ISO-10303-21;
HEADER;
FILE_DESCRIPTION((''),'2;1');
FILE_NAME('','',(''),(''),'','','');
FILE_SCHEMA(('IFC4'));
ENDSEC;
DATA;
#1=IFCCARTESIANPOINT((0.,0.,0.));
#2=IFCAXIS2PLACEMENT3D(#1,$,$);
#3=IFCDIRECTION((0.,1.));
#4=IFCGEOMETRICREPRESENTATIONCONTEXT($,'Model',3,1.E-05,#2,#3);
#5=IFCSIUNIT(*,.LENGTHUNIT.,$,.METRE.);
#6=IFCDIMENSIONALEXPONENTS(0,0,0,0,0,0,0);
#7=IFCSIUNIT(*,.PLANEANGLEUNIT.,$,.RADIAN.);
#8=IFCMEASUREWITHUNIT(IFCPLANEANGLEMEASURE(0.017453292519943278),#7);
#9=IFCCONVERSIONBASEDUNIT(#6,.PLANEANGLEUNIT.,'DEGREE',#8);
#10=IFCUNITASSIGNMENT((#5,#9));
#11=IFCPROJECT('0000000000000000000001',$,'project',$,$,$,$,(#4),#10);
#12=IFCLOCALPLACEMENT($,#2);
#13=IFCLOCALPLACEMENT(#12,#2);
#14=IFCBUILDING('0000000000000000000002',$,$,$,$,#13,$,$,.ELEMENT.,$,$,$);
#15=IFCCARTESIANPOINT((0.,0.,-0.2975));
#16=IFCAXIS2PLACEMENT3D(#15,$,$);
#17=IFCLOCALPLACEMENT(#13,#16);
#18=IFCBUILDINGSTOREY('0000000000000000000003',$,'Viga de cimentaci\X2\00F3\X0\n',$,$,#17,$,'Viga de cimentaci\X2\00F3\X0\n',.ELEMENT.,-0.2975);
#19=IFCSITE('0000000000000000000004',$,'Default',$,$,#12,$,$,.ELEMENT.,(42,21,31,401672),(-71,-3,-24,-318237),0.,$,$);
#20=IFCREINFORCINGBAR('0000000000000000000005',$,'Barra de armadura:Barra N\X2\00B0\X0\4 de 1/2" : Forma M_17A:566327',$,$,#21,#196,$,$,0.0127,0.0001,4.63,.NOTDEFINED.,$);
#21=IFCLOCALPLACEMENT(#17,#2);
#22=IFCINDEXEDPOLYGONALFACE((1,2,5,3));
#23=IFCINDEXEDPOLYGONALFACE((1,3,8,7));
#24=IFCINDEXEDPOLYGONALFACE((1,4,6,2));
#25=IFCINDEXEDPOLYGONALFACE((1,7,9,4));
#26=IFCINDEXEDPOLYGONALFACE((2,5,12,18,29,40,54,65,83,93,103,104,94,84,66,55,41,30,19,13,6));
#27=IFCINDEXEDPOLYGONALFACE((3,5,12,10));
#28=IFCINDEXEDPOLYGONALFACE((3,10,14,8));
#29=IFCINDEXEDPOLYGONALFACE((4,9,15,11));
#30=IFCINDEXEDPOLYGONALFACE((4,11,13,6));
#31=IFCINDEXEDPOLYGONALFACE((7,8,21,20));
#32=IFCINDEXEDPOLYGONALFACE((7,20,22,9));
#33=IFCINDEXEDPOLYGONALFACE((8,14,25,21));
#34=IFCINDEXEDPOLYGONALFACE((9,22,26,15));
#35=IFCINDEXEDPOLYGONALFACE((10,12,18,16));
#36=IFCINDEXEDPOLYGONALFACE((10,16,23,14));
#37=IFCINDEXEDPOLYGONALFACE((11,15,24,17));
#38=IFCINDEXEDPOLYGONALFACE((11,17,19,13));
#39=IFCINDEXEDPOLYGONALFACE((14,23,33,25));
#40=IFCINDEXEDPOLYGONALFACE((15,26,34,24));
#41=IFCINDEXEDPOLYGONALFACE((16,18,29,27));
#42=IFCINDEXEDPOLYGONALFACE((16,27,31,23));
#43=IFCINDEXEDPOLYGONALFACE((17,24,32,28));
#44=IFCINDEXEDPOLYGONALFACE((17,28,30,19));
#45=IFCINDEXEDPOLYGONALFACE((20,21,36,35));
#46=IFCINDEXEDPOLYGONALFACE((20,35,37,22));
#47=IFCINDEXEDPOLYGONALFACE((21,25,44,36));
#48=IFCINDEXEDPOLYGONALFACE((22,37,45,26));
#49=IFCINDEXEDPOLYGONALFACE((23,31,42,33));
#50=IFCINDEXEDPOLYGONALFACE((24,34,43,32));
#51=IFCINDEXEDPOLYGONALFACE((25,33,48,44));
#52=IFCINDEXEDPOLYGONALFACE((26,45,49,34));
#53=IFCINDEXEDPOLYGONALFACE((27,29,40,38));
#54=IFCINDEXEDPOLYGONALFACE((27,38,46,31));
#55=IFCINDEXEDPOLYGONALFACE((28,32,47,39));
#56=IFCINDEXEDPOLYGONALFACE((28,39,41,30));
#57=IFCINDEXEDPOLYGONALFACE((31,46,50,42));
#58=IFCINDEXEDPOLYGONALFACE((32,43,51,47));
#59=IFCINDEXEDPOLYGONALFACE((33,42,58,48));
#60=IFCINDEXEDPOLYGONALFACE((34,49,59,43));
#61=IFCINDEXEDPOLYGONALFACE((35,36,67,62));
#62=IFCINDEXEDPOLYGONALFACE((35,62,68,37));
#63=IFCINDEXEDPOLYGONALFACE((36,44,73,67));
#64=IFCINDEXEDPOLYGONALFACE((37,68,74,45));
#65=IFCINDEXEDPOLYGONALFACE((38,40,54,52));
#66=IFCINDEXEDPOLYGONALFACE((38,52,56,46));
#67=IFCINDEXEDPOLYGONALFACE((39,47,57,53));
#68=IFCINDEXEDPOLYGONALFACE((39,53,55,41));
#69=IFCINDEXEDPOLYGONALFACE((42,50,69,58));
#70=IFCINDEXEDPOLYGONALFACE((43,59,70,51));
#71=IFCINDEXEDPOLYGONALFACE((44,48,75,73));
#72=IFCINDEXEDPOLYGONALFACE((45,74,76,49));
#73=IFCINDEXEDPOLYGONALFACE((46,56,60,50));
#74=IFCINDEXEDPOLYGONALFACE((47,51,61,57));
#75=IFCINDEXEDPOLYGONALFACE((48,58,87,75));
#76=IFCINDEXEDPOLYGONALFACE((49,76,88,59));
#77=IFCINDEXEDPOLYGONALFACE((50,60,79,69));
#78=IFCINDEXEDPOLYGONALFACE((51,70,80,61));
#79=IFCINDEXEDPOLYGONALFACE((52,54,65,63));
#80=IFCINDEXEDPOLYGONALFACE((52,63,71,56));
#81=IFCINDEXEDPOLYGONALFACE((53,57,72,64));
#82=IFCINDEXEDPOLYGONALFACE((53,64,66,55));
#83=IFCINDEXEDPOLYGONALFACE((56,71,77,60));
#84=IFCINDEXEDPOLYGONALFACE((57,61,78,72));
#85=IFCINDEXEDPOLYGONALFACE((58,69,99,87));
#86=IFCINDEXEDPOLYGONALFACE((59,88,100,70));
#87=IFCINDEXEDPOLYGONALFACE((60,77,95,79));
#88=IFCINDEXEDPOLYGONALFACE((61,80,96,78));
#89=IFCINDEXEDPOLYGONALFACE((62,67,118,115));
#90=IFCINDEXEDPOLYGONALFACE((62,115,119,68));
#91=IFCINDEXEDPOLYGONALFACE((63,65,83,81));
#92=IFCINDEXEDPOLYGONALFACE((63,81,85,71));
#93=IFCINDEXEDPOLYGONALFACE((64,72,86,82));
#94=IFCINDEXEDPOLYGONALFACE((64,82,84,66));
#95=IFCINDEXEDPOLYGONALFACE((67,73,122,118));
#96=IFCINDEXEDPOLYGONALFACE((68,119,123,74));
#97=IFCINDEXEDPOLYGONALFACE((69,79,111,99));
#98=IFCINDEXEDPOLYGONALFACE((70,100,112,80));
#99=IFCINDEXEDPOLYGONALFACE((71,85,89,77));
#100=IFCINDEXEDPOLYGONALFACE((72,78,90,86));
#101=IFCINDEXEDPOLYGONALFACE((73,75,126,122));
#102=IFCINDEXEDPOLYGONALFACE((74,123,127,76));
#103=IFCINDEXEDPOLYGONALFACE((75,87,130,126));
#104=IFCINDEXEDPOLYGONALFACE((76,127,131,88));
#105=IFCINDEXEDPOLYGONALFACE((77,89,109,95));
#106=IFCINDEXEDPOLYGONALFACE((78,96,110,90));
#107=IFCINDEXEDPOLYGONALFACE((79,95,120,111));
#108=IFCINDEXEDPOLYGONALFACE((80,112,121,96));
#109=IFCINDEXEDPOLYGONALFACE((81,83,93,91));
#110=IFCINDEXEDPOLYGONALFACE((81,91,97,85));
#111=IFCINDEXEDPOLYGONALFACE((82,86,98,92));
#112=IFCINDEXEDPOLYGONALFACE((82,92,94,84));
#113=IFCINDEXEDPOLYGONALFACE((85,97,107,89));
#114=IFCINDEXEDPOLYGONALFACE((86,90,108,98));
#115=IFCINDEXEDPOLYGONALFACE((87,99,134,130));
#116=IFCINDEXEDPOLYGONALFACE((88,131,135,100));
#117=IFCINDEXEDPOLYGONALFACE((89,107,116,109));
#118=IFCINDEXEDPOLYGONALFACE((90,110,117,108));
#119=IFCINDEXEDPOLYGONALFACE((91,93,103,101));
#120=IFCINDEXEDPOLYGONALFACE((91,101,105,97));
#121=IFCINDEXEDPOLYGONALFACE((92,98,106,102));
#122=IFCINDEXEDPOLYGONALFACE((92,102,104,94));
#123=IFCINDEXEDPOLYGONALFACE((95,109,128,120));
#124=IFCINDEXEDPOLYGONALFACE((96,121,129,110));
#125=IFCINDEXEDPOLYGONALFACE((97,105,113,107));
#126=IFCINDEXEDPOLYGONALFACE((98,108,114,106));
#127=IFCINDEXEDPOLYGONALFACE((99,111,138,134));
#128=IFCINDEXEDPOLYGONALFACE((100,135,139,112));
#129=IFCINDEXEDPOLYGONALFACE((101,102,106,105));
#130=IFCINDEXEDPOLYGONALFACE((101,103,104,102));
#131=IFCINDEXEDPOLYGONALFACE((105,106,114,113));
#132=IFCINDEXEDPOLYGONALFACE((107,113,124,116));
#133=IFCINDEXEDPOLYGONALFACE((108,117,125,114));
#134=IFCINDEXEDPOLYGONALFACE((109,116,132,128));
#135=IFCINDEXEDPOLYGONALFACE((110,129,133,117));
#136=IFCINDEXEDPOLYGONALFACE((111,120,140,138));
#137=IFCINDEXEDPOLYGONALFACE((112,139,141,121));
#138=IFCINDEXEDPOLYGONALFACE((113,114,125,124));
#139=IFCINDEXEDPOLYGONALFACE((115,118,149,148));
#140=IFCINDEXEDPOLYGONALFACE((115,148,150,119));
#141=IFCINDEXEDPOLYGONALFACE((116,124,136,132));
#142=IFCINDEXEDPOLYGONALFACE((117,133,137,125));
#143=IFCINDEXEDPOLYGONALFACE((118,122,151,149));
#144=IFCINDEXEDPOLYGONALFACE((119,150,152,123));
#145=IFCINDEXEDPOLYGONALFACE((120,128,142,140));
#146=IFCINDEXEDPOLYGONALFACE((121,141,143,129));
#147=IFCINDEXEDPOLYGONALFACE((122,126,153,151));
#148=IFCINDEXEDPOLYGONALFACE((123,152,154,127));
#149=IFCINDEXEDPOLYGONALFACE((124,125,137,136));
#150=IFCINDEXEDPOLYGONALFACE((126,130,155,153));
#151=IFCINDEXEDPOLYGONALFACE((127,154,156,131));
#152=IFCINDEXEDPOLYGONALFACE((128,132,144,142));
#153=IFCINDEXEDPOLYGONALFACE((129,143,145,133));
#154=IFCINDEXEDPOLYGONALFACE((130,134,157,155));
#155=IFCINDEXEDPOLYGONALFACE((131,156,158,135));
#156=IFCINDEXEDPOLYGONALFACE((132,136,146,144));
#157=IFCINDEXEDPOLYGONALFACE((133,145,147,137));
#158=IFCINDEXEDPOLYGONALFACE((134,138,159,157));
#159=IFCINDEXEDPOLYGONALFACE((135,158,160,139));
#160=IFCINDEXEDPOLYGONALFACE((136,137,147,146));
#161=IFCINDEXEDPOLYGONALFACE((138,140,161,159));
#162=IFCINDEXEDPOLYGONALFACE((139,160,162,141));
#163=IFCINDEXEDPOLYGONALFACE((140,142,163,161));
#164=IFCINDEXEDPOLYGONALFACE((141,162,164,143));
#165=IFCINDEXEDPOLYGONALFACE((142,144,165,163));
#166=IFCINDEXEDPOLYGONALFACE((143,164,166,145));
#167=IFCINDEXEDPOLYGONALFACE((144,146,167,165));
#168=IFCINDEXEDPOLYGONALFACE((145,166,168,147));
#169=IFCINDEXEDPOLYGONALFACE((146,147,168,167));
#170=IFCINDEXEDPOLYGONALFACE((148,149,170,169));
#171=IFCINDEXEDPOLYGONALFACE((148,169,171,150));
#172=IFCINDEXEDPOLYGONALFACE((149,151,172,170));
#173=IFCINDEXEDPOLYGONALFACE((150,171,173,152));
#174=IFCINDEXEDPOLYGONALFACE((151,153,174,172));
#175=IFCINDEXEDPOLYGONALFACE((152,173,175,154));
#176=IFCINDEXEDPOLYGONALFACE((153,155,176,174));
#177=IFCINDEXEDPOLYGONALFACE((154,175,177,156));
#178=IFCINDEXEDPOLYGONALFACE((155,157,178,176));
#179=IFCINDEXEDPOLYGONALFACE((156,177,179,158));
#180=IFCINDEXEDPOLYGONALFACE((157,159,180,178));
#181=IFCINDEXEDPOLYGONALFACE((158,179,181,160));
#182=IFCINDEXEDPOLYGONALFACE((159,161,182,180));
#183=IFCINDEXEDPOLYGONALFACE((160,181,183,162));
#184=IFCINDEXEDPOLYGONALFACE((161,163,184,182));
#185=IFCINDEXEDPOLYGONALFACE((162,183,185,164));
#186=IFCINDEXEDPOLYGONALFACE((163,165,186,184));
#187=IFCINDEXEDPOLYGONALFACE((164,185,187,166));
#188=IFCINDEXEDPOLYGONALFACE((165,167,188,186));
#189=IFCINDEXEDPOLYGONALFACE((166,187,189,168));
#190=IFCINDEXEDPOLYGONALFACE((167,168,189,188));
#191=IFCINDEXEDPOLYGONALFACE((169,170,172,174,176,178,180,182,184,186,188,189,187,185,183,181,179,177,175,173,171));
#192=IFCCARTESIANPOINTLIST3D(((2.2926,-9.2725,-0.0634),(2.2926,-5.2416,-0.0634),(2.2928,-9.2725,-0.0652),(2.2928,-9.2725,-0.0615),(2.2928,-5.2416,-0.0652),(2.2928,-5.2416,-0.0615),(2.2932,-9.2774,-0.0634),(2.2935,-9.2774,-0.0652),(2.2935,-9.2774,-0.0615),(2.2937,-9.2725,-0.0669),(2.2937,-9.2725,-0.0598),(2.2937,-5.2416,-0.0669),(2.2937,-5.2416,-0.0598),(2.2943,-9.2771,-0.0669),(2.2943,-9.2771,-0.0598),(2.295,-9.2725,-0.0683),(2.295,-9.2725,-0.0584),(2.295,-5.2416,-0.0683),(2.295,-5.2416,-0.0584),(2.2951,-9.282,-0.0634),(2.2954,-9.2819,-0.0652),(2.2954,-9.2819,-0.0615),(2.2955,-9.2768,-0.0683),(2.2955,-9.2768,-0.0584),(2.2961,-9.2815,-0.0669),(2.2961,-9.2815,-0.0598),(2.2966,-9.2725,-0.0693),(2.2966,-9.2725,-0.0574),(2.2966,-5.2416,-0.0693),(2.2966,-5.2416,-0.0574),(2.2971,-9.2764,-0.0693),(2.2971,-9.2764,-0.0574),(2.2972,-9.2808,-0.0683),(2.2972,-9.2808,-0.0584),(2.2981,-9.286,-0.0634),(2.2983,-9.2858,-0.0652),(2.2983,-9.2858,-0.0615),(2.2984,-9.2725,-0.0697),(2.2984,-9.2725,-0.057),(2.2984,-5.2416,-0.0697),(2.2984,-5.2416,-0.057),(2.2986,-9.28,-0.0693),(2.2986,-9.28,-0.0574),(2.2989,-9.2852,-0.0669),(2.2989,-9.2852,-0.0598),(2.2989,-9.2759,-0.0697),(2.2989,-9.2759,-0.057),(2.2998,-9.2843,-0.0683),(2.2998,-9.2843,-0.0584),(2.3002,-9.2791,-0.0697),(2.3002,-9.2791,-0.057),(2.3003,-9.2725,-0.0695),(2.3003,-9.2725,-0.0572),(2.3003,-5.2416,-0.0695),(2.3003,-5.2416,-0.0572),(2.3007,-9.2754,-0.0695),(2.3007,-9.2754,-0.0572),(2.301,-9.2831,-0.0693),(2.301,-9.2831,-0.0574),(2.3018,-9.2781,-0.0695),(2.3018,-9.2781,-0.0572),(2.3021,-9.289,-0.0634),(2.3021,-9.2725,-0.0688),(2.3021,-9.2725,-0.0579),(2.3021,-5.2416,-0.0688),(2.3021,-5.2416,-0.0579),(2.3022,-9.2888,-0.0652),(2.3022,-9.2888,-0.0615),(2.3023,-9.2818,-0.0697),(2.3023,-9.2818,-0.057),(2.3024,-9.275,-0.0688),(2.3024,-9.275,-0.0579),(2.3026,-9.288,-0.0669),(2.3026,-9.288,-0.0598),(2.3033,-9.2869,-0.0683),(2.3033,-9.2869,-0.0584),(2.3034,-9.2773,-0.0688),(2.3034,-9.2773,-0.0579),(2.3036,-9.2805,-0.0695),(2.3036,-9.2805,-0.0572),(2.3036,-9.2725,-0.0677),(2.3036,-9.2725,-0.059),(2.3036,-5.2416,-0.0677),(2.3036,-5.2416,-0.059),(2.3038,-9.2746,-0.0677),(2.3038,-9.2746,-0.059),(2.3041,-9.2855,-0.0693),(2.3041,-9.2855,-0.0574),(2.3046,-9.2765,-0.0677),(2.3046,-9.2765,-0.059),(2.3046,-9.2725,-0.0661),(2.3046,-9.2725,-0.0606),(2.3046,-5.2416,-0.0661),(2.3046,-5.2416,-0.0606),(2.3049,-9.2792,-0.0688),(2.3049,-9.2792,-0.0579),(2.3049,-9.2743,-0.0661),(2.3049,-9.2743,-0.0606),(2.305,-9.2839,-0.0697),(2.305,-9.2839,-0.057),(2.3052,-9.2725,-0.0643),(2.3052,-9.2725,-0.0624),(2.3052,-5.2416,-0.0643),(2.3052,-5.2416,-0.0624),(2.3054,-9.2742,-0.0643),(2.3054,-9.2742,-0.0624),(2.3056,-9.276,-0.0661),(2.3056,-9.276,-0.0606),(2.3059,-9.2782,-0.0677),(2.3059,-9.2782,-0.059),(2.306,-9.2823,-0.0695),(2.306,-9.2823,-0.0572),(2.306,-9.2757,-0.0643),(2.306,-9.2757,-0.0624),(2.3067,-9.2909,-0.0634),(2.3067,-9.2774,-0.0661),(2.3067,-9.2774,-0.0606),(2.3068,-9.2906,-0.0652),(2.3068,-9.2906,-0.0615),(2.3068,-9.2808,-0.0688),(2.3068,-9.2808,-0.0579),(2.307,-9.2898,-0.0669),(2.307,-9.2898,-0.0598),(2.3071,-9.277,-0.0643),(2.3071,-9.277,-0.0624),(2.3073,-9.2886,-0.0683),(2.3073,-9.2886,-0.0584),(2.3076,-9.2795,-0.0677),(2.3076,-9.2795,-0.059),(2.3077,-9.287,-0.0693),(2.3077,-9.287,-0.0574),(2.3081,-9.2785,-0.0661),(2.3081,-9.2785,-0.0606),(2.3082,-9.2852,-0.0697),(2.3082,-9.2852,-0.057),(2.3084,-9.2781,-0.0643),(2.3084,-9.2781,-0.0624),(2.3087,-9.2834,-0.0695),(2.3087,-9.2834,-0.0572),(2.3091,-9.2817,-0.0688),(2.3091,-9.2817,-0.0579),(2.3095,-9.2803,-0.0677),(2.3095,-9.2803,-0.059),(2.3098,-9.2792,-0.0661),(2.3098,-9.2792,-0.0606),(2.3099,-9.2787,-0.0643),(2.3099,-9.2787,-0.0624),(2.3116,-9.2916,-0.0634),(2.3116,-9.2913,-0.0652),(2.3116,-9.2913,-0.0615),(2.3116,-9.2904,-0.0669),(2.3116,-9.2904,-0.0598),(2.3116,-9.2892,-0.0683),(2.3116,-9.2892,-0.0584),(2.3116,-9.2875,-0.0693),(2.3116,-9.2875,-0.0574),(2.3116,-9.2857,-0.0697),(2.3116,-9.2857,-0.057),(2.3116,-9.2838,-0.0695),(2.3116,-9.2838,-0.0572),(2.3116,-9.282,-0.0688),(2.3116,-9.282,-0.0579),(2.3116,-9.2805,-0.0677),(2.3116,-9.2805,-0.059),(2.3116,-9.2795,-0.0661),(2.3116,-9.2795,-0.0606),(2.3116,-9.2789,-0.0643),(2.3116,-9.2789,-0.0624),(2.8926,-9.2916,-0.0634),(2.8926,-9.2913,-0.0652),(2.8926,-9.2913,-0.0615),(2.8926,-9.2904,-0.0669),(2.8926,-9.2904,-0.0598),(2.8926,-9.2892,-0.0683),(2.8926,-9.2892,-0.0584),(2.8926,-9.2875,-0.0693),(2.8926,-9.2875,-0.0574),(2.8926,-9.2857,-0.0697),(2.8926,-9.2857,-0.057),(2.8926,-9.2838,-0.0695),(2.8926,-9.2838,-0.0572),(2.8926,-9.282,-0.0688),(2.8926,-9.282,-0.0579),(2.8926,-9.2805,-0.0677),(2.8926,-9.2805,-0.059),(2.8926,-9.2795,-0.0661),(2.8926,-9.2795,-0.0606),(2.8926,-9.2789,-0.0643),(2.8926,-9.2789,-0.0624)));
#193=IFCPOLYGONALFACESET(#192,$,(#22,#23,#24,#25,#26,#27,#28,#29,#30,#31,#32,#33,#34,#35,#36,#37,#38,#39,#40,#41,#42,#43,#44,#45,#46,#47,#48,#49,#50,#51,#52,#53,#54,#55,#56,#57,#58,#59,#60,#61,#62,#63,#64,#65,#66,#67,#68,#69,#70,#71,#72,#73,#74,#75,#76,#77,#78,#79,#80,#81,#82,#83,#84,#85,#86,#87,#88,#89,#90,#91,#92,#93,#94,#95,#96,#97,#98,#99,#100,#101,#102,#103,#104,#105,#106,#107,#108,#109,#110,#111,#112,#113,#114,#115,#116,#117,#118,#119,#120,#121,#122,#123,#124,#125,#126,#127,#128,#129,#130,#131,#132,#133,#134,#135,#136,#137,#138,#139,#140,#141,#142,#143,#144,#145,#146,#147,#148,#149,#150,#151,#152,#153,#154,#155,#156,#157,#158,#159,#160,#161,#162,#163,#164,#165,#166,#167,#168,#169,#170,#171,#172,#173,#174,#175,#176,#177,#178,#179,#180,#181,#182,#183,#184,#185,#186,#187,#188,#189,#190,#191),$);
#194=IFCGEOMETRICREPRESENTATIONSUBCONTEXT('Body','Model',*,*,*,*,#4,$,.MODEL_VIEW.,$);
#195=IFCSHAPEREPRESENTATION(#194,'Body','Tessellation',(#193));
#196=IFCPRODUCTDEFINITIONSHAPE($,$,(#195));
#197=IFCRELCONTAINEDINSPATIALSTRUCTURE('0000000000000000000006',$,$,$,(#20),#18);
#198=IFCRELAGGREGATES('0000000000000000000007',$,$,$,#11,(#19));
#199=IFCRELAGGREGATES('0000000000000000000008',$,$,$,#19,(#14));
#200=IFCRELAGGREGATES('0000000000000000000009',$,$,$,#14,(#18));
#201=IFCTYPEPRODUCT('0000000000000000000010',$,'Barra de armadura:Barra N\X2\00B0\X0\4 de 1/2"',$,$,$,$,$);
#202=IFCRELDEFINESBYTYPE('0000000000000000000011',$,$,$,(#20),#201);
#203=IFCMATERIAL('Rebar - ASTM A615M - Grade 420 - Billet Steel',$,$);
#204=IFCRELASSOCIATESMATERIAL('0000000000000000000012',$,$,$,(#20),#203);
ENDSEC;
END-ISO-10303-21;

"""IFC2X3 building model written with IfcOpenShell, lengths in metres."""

from ifc_helpers import new_model, entity, si_unit, converted_unit, direction, frame, origin, place, context, subcontext, project, spatial, material, type_object, element, save


model = new_model("IFC2X3")

# Units and contexts
model_context = context("Model", 3, precision=1e-05, world=origin(), true_north=direction((0.0, 1.0)))
body_context = subcontext(model_context, "Body", "Model", "MODEL_VIEW")
ifc_project = project(units=[si_unit("LENGTHUNIT", "METRE"), converted_unit("PLANEANGLEUNIT", "DEGREE", entity("IfcPlaneAngleMeasure", 0.017453292519943278), si_unit("PLANEANGLEUNIT", "RADIAN"), dimensions=[0, 0, 0, 0, 0, 0, 0])], contexts=[model_context])

# Site, building, storey
site_placement = place(None, origin())
site = spatial("IfcSite", under=ifc_project, at=site_placement, Name="Default", CompositionType="ELEMENT", RefLatitude=(42, 21, 31, 401672), RefLongitude=(-71, -3, -24, -318237), RefElevation=0.0)
building_placement = place(site_placement, origin())
building = spatial("IfcBuilding", under=site, at=building_placement, CompositionType="ELEMENT")
storey_placement = place(building_placement, frame((0.0, 0.0, -0.2975)))
storey = spatial("IfcBuildingStorey", under=building, at=storey_placement, Name="Viga de cimentación", LongName="Viga de cimentación", CompositionType="ELEMENT", Elevation=-0.2975)

# Reinforcing bar
ifc_material = material(Name="Rebar - ASTM A615M - Grade 420 - Billet Steel")
type_product_1 = type_object("IfcTypeProduct", Name="Barra de armadura:Barra N°4 de 1/2\"")
reinforcing_bar_1_placement = place(storey_placement, origin())
element("IfcReinforcingBar", 1, at=reinforcing_bar_1_placement, inside=storey, type_object=type_product_1, material=ifc_material, Name="Barra de armadura:Barra N°4 de 1/2\" : Forma M_17A:566327", BarLength=4.63, BarRole="NOTDEFINED", CrossSectionArea=0.0001, NominalDiameter=0.0127, context=body_context, shape_type="AdvancedSweptSolid", body=[
    entity("IfcSweptDiskSolid", entity("IfcCompositeCurve", [entity("IfcCompositeCurveSegment", "CONTINUOUS", True, entity("IfcPolyline", [entity("IfcCartesianPoint", [2.2989, -5.2416, -0.0634]), entity("IfcCartesianPoint", [2.2989, -9.2725, -0.0634])])), entity("IfcCompositeCurveSegment", "CONTINUOUS", True, entity("IfcTrimmedCurve", entity("IfcCircle", entity("IfcAxis2Placement3D", entity("IfcCartesianPoint", [2.3116, -9.2725, -0.0634]), entity("IfcDirection", [0.0, 0.0, 1.0]), entity("IfcDirection", [0.0, -1.0, 0.0])), 0.0127), [entity("IfcParameterValue", 270.0)], [entity("IfcParameterValue", 360.0)], True, "PARAMETER")), entity("IfcCompositeCurveSegment", "CONTINUOUS", True, entity("IfcPolyline", [entity("IfcCartesianPoint", [2.3116, -9.2852, -0.0634]), entity("IfcCartesianPoint", [2.8926, -9.2852, -0.0634])]))], False), 0.0063, None, 0.0, 92.0),
])

save(model, "model.ifc")
